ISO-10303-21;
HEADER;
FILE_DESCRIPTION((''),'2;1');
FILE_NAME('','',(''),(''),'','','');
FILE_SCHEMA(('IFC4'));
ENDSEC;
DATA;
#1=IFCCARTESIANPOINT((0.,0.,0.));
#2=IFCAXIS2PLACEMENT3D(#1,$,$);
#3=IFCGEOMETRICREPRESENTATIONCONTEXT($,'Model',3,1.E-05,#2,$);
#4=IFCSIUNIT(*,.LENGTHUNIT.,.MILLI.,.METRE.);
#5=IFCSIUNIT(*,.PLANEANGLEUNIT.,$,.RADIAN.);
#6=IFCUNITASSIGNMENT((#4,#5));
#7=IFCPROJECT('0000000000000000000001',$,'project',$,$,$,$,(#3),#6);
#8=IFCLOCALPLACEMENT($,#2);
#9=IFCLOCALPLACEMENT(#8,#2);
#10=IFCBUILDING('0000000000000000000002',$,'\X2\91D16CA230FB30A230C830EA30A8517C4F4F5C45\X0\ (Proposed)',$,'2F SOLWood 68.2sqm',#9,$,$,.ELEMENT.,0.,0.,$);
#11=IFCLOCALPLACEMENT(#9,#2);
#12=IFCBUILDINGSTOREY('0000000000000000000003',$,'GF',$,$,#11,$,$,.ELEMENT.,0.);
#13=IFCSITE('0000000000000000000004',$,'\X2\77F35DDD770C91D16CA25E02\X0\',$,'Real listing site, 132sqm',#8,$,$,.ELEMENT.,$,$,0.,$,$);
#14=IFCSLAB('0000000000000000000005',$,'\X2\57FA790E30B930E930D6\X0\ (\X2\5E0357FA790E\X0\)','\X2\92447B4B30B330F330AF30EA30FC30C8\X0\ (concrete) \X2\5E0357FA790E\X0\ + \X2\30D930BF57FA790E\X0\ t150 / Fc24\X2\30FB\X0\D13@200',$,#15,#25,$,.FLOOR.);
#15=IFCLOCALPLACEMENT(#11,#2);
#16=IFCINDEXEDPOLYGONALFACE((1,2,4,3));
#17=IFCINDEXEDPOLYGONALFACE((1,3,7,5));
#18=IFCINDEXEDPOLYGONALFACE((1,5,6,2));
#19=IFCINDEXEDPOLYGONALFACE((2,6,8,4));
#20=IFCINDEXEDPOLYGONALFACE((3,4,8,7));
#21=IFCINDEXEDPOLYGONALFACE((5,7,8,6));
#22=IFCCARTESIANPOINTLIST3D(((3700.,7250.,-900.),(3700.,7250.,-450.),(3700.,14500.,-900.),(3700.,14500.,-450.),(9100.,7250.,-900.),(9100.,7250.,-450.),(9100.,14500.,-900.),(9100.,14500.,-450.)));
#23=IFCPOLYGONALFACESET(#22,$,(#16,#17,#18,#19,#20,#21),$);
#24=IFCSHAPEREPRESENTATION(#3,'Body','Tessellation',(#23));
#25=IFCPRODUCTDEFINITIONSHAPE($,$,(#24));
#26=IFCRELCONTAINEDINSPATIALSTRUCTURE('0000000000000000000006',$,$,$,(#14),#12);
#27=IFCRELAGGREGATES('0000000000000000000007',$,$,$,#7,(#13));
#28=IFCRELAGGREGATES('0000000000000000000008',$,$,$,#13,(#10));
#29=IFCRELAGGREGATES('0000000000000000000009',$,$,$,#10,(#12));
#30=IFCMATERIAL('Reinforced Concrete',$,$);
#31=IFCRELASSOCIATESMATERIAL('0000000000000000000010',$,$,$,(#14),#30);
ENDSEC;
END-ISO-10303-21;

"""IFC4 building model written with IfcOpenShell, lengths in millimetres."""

from ifc_helpers import new_model, si_unit, frame, frame_2d, origin, place, context, project, spatial, rectangle, extrude, material, element, save


model = new_model("IFC4")

# Units and contexts
model_context = context("Model", 3, precision=1e-05, world=origin())
ifc_project = project(units=[si_unit("LENGTHUNIT", "METRE", prefix="MILLI"), si_unit("PLANEANGLEUNIT", "RADIAN")], contexts=[model_context])

# Site, building, storey
site_placement = place(None, origin())
site = spatial("IfcSite", under=ifc_project, at=site_placement, Name="石川県金沢市", ObjectType="Real listing site, 132sqm", CompositionType="ELEMENT", RefElevation=0.0)
building_placement = place(site_placement, origin())
building = spatial("IfcBuilding", under=site, at=building_placement, Name="金沢・アトリエ兼住居 (Proposed)", ObjectType="2F SOLWood 68.2sqm", CompositionType="ELEMENT", ElevationOfRefHeight=0.0, ElevationOfTerrain=0.0)
storey_placement = place(building_placement, origin())
storey = spatial("IfcBuildingStorey", under=building, at=storey_placement, Name="GF", CompositionType="ELEMENT", Elevation=0.0)

# Slab
ifc_material_1 = material(Name="Reinforced Concrete")
slab_1_placement = place(storey_placement, frame((1850.0, 3625.0, -450.0)))
element("IfcSlab", 1, at=slab_1_placement, inside=storey, material=ifc_material_1, Name="基礎スラブ (布基礎)", Description="鉄筋コンクリート (concrete) 布基礎 + ベタ基礎 t150 / Fc24・D13@200", PredefinedType="FLOOR", context=model_context, shape_type="SweptSolid", body=[
    extrude(rectangle(XDim=5400.0, YDim=7250.0, at=frame_2d((2700.0, 3625.0))), frame((1850.0, 3625.0, -450.0)), (0.0, 0.0, 1.0), 450.0),
])

save(model, "model.ifc")
